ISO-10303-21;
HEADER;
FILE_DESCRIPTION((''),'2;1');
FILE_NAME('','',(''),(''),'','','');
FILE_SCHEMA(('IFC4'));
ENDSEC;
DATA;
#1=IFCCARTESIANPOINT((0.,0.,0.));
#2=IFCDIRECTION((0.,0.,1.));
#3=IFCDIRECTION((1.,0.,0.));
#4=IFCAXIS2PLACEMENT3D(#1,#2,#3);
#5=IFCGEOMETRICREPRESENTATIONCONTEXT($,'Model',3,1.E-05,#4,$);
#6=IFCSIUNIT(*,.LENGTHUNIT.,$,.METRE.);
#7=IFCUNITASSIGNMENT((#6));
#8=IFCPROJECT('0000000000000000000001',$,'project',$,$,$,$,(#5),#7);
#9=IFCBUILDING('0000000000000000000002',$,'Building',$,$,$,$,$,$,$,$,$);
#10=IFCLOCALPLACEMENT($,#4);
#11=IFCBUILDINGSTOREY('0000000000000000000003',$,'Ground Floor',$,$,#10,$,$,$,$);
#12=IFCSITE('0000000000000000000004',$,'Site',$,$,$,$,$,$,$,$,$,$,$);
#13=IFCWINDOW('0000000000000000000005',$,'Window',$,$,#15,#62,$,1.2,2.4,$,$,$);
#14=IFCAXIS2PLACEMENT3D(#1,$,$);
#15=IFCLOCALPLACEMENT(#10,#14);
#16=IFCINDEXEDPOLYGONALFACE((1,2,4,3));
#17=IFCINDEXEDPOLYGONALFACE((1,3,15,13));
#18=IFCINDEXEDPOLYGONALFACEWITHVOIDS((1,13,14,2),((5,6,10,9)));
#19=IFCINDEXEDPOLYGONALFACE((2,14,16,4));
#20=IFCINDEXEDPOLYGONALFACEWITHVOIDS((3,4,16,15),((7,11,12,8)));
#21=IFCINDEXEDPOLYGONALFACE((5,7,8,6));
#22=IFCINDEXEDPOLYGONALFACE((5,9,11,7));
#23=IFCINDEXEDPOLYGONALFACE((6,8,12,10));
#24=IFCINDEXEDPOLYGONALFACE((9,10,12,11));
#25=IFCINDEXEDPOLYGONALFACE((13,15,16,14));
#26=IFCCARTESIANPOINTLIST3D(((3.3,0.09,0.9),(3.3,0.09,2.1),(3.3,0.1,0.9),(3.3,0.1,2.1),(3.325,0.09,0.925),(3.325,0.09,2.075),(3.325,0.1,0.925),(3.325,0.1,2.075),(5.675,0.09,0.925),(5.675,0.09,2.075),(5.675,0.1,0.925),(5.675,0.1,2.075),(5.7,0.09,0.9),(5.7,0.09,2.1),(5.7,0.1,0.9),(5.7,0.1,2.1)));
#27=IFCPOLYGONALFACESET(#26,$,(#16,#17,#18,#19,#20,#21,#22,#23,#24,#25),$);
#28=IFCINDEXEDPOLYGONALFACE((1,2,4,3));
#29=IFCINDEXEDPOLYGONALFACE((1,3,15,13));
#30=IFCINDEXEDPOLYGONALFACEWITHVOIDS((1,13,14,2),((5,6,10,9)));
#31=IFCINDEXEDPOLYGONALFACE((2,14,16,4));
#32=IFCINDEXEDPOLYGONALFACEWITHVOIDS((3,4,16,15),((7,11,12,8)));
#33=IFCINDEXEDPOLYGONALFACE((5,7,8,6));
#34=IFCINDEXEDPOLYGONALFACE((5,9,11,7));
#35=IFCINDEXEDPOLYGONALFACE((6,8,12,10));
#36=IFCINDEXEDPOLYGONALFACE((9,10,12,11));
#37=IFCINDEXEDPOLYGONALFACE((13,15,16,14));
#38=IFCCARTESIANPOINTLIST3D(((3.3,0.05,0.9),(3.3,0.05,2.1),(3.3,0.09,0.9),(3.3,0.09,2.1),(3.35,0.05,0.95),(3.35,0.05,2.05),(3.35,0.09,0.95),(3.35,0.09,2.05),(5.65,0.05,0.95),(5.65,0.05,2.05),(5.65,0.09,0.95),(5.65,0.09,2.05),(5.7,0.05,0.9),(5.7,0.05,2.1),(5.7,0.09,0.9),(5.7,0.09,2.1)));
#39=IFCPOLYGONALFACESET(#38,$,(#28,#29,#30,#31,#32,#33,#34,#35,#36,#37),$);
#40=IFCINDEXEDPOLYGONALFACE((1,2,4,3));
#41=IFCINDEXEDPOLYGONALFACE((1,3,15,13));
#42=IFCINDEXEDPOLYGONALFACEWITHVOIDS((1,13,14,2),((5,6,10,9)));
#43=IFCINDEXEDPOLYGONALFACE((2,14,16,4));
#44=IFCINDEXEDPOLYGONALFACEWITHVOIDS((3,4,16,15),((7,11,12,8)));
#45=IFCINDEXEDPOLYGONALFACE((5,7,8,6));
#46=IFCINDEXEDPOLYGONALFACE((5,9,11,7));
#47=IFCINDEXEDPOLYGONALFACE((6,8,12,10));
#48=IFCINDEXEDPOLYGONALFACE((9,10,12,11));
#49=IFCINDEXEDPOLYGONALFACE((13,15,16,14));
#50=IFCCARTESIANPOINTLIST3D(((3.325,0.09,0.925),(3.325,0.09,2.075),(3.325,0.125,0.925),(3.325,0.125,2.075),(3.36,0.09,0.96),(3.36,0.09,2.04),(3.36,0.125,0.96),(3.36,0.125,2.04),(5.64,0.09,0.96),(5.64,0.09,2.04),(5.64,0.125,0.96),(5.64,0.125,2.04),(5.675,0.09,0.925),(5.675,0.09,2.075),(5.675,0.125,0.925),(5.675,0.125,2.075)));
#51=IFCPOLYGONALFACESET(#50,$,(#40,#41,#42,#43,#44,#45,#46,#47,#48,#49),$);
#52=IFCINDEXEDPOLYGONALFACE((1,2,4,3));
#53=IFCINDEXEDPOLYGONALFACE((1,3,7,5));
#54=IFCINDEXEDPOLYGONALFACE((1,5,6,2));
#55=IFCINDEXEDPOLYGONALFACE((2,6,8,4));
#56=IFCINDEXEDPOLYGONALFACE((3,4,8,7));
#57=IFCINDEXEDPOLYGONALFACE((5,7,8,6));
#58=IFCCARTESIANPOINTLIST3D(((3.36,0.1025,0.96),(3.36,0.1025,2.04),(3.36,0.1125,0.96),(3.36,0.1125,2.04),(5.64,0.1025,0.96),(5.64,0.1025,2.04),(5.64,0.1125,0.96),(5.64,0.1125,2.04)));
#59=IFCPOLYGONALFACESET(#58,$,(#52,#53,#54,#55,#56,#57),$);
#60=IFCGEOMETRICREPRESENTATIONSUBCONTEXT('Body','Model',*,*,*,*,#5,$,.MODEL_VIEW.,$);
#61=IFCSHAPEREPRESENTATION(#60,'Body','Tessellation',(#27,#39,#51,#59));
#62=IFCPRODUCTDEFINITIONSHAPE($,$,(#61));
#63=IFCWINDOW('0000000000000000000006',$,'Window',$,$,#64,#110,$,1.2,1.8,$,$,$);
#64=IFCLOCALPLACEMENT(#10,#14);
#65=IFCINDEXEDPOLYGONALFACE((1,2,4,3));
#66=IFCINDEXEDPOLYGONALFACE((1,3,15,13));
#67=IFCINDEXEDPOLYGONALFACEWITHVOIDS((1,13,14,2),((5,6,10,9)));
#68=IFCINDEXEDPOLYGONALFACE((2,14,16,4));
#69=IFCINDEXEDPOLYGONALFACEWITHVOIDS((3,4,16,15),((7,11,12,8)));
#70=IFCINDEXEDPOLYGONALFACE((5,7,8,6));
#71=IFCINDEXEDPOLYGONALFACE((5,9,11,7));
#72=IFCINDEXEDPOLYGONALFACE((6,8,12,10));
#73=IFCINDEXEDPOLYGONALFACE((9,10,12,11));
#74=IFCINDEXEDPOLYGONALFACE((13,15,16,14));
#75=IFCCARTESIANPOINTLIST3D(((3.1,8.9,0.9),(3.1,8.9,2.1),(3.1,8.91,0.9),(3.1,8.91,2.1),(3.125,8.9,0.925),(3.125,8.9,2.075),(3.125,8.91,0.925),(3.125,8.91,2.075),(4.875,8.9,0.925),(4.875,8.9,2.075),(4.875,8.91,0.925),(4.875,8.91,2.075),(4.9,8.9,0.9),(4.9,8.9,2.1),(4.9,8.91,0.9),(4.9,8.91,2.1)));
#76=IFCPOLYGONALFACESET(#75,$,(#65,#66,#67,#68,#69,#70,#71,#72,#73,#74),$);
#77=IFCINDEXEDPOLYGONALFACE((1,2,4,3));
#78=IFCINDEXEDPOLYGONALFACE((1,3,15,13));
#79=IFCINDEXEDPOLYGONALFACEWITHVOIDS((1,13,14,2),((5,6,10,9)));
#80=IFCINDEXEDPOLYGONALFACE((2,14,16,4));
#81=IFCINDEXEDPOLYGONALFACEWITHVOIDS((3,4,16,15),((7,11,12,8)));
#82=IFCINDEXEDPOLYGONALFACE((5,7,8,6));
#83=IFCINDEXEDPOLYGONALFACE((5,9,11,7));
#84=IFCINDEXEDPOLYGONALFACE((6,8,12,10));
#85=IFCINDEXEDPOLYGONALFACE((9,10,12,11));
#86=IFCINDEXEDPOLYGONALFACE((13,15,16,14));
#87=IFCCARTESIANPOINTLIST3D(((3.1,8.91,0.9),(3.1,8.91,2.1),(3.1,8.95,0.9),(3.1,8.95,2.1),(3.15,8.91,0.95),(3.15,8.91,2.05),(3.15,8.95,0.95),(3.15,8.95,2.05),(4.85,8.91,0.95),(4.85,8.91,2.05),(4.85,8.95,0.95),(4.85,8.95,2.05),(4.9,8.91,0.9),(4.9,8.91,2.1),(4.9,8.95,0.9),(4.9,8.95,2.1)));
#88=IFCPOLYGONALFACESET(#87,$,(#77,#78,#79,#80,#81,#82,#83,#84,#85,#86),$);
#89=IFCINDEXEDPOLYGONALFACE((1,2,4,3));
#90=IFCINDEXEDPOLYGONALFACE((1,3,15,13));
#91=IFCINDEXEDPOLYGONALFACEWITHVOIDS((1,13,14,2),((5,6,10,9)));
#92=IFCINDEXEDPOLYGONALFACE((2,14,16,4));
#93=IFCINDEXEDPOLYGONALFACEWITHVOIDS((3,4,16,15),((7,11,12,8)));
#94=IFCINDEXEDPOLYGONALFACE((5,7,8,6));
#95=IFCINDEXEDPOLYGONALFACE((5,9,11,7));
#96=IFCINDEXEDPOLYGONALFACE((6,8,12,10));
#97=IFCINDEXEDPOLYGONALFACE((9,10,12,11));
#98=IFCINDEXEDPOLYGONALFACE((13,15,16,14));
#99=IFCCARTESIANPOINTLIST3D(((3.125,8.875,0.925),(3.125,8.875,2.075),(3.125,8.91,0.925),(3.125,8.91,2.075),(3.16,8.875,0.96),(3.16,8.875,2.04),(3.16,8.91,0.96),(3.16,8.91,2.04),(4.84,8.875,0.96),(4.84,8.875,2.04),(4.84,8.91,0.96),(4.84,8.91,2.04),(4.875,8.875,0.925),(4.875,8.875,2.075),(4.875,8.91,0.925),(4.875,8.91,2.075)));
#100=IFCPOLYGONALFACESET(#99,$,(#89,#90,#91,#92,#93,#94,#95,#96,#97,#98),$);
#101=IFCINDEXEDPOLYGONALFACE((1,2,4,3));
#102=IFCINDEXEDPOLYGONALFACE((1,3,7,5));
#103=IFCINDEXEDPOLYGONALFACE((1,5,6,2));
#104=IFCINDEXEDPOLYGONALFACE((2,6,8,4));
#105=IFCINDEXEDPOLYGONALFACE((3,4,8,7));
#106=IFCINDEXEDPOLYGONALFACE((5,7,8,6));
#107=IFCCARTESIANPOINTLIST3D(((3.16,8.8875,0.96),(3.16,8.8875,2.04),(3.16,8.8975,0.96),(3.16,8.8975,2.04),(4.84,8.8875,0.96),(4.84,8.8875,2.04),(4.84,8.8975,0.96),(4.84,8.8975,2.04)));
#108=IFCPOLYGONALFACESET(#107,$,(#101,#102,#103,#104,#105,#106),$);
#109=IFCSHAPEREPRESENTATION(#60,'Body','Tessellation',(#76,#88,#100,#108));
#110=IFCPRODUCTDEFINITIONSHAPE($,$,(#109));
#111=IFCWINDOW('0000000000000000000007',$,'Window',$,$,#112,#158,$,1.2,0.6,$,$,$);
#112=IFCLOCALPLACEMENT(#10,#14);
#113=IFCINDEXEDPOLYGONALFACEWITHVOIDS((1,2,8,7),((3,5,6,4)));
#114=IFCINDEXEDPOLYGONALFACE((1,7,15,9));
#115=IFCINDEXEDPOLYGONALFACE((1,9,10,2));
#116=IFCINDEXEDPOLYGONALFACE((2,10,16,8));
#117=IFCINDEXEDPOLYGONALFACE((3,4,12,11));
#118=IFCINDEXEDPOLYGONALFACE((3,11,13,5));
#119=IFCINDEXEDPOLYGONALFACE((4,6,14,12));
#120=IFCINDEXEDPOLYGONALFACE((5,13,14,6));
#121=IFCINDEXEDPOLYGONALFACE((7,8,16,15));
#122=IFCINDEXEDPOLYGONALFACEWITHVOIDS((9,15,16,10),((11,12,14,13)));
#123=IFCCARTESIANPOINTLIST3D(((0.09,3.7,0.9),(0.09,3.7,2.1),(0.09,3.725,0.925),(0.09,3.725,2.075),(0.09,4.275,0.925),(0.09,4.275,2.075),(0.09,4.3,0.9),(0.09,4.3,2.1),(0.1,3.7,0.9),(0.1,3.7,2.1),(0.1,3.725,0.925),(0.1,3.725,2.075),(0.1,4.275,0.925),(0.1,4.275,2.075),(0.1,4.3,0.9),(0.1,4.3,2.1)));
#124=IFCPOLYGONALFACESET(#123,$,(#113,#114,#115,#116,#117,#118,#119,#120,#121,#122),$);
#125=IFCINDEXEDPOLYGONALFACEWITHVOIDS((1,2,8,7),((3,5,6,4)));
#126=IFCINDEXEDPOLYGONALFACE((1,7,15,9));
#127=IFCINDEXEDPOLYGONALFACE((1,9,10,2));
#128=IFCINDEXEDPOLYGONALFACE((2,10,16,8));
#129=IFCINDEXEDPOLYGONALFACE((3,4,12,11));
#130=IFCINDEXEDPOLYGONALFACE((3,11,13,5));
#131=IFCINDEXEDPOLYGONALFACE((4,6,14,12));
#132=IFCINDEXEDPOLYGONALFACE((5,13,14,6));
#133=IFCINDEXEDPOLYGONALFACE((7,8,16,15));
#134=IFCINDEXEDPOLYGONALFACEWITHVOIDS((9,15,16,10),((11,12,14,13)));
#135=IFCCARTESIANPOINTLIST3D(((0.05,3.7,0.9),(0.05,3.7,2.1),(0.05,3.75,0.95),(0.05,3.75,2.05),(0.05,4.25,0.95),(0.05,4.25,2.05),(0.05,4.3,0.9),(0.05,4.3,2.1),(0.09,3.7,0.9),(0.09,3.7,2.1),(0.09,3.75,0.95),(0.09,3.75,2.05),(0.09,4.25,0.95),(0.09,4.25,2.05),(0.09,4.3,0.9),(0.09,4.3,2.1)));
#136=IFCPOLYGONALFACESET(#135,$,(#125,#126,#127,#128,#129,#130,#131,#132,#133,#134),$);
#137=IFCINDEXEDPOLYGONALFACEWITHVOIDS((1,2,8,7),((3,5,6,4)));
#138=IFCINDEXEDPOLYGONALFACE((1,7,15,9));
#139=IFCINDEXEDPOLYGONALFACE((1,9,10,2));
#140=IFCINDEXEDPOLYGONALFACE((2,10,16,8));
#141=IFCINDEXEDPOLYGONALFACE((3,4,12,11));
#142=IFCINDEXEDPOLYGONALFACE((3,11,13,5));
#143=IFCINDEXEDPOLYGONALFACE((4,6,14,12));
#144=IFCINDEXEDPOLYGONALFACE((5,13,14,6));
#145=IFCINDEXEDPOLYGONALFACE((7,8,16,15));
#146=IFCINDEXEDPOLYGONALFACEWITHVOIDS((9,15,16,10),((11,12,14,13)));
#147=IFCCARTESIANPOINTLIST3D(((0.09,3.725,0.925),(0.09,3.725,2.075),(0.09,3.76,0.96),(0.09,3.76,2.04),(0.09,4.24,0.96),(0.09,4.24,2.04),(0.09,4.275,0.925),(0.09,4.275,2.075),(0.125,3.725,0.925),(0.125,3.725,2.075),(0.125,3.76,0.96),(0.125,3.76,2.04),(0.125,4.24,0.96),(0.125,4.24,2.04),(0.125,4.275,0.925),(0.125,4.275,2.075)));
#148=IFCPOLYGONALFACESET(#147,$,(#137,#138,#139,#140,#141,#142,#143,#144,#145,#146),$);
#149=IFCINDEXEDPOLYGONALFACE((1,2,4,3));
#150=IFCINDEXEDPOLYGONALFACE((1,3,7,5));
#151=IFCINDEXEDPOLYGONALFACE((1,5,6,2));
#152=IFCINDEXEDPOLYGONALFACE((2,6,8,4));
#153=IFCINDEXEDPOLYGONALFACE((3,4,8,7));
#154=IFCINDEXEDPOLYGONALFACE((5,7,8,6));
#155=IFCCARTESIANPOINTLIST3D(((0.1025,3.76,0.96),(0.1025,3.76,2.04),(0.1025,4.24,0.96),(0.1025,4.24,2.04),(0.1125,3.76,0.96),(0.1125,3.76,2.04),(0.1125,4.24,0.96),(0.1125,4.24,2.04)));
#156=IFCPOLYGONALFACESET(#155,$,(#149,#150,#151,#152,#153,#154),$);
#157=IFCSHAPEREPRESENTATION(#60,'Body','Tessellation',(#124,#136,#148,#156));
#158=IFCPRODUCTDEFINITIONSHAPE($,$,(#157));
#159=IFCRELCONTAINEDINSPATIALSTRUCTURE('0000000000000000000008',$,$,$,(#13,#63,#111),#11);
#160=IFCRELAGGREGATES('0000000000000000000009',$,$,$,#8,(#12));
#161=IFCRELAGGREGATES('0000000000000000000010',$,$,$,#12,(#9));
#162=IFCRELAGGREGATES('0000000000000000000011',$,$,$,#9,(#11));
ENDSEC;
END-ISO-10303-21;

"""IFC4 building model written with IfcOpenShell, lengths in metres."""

from ifc_helpers import new_model, si_unit, frame, origin_with_axes, place, context, subcontext, project, spatial, line, indexed_curve, outline, extrude, element, save


model = new_model("IFC4")

# Units and contexts
model_context = context("Model", 3, precision=1e-05, world=origin_with_axes())
body_context = subcontext(model_context, "Body", "Model", "MODEL_VIEW")
ifc_project = project(units=[si_unit("LENGTHUNIT", "METRE")], contexts=[model_context])

# Site, building, storey
site = spatial("IfcSite", under=ifc_project, Name="Site")
building = spatial("IfcBuilding", under=site, Name="Building")
storey_placement = place(None, origin_with_axes())
storey = spatial("IfcBuildingStorey", under=building, at=storey_placement, Name="Ground Floor")

# Windows
window_1_placement = place(storey_placement, frame((3.3, 0.0, 0.9), z_axis=(0.0, 0.0, 1.0), x_axis=(1.0, 0.0, 0.0)))
element("IfcWindow", 1, at=window_1_placement, inside=storey, Name="Window", OverallHeight=1.2, OverallWidth=2.4, context=body_context, shape_type="SweptSolid", body=[
    extrude(outline(indexed_curve([(0.0, 0.0), (2.4, 0.0), (2.4, 1.2), (0.0, 1.2)], segments=[line(1, 2, 3, 4, 1)]), holes=[indexed_curve([(0.025, 0.025), (2.375, 0.025), (2.375, 1.175), (0.025, 1.175)], segments=[line(1, 2, 3, 4, 1)])]), frame((0.0, 0.09, 0.0), z_axis=(0.0, -1.0, 0.0), x_axis=(1.0, 0.0, 0.0)), (0.0, 0.0, -1.0), 0.01),
    extrude(outline(indexed_curve([(0.0, 0.0), (2.4, 0.0), (2.4, 1.2), (0.0, 1.2)], segments=[line(1, 2, 3, 4, 1)]), holes=[indexed_curve([(0.05, 0.05), (2.35, 0.05), (2.35, 1.15), (0.05, 1.15)], segments=[line(1, 2, 3, 4, 1)])]), frame((0.0, 0.05, 0.0), z_axis=(0.0, -1.0, 0.0), x_axis=(1.0, 0.0, 0.0)), (0.0, 0.0, -1.0), 0.04),
    extrude(outline(indexed_curve([(0.0, 0.0), (2.35, 0.0), (2.35, 1.15), (0.0, 1.15)], segments=[line(1, 2, 3, 4, 1)]), holes=[indexed_curve([(0.035, 0.035), (2.315, 0.035), (2.315, 1.115), (0.035, 1.115)], segments=[line(1, 2, 3, 4, 1)])]), frame((0.025, 0.09, 0.025), z_axis=(0.0, -1.0, 0.0), x_axis=(1.0, 0.0, 0.0)), (0.0, 0.0, -1.0), 0.035),
    extrude(outline(indexed_curve([(0.035, 0.035), (2.315, 0.035), (2.315, 1.115), (0.035, 1.115)], segments=[line(1, 2, 3, 4, 1)])), frame((0.025, 0.1025, 0.025), z_axis=(0.0, -1.0, 0.0), x_axis=(1.0, 0.0, 0.0)), (0.0, 0.0, -1.0), 0.01),
])
window_2_placement = place(storey_placement, frame((4.9, 9.0, 0.9), z_axis=(0.0, 0.0, 1.0), x_axis=(-1.0, 0.0, 0.0)))
element("IfcWindow", 2, at=window_2_placement, inside=storey, Name="Window", OverallHeight=1.2, OverallWidth=1.8, context=body_context, shape_type="SweptSolid", body=[
    extrude(outline(indexed_curve([(0.0, 0.0), (1.8, 0.0), (1.8, 1.2), (0.0, 1.2)], segments=[line(1, 2, 3, 4, 1)]), holes=[indexed_curve([(0.025, 0.025), (1.775, 0.025), (1.775, 1.175), (0.025, 1.175)], segments=[line(1, 2, 3, 4, 1)])]), frame((0.0, 0.09, 0.0), z_axis=(0.0, -1.0, 0.0), x_axis=(1.0, 0.0, 0.0)), (0.0, 0.0, -1.0), 0.01),
    extrude(outline(indexed_curve([(0.0, 0.0), (1.8, 0.0), (1.8, 1.2), (0.0, 1.2)], segments=[line(1, 2, 3, 4, 1)]), holes=[indexed_curve([(0.05, 0.05), (1.75, 0.05), (1.75, 1.15), (0.05, 1.15)], segments=[line(1, 2, 3, 4, 1)])]), frame((0.0, 0.05, 0.0), z_axis=(0.0, -1.0, 0.0), x_axis=(1.0, 0.0, 0.0)), (0.0, 0.0, -1.0), 0.04),
    extrude(outline(indexed_curve([(0.0, 0.0), (1.75, 0.0), (1.75, 1.15), (0.0, 1.15)], segments=[line(1, 2, 3, 4, 1)]), holes=[indexed_curve([(0.035, 0.035), (1.715, 0.035), (1.715, 1.115), (0.035, 1.115)], segments=[line(1, 2, 3, 4, 1)])]), frame((0.025, 0.09, 0.025), z_axis=(0.0, -1.0, 0.0), x_axis=(1.0, 0.0, 0.0)), (0.0, 0.0, -1.0), 0.035),
    extrude(outline(indexed_curve([(0.035, 0.035), (1.715, 0.035), (1.715, 1.115), (0.035, 1.115)], segments=[line(1, 2, 3, 4, 1)])), frame((0.025, 0.1025, 0.025), z_axis=(0.0, -1.0, 0.0), x_axis=(1.0, 0.0, 0.0)), (0.0, 0.0, -1.0), 0.01),
])
window_3_placement = place(storey_placement, frame((0.0, 4.3, 0.9), z_axis=(0.0, 0.0, 1.0), x_axis=(0.0, -1.0, 0.0)))
element("IfcWindow", 3, at=window_3_placement, inside=storey, Name="Window", OverallHeight=1.2, OverallWidth=0.6, context=body_context, shape_type="SweptSolid", body=[
    extrude(outline(indexed_curve([(0.0, 0.0), (0.6, 0.0), (0.6, 1.2), (0.0, 1.2)], segments=[line(1, 2, 3, 4, 1)]), holes=[indexed_curve([(0.025, 0.025), (0.575, 0.025), (0.575, 1.175), (0.025, 1.175)], segments=[line(1, 2, 3, 4, 1)])]), frame((0.0, 0.09, 0.0), z_axis=(0.0, -1.0, 0.0), x_axis=(1.0, 0.0, 0.0)), (0.0, 0.0, -1.0), 0.01),
    extrude(outline(indexed_curve([(0.0, 0.0), (0.6, 0.0), (0.6, 1.2), (0.0, 1.2)], segments=[line(1, 2, 3, 4, 1)]), holes=[indexed_curve([(0.05, 0.05), (0.55, 0.05), (0.55, 1.15), (0.05, 1.15)], segments=[line(1, 2, 3, 4, 1)])]), frame((0.0, 0.05, 0.0), z_axis=(0.0, -1.0, 0.0), x_axis=(1.0, 0.0, 0.0)), (0.0, 0.0, -1.0), 0.04),
    extrude(outline(indexed_curve([(0.0, 0.0), (0.55, 0.0), (0.55, 1.15), (0.0, 1.15)], segments=[line(1, 2, 3, 4, 1)]), holes=[indexed_curve([(0.035, 0.035), (0.515, 0.035), (0.515, 1.115), (0.035, 1.115)], segments=[line(1, 2, 3, 4, 1)])]), frame((0.025, 0.09, 0.025), z_axis=(0.0, -1.0, 0.0), x_axis=(1.0, 0.0, 0.0)), (0.0, 0.0, -1.0), 0.035),
    extrude(outline(indexed_curve([(0.035, 0.035), (0.515, 0.035), (0.515, 1.115), (0.035, 1.115)], segments=[line(1, 2, 3, 4, 1)])), frame((0.025, 0.1025, 0.025), z_axis=(0.0, -1.0, 0.0), x_axis=(1.0, 0.0, 0.0)), (0.0, 0.0, -1.0), 0.01),
])

save(model, "model.ifc")
